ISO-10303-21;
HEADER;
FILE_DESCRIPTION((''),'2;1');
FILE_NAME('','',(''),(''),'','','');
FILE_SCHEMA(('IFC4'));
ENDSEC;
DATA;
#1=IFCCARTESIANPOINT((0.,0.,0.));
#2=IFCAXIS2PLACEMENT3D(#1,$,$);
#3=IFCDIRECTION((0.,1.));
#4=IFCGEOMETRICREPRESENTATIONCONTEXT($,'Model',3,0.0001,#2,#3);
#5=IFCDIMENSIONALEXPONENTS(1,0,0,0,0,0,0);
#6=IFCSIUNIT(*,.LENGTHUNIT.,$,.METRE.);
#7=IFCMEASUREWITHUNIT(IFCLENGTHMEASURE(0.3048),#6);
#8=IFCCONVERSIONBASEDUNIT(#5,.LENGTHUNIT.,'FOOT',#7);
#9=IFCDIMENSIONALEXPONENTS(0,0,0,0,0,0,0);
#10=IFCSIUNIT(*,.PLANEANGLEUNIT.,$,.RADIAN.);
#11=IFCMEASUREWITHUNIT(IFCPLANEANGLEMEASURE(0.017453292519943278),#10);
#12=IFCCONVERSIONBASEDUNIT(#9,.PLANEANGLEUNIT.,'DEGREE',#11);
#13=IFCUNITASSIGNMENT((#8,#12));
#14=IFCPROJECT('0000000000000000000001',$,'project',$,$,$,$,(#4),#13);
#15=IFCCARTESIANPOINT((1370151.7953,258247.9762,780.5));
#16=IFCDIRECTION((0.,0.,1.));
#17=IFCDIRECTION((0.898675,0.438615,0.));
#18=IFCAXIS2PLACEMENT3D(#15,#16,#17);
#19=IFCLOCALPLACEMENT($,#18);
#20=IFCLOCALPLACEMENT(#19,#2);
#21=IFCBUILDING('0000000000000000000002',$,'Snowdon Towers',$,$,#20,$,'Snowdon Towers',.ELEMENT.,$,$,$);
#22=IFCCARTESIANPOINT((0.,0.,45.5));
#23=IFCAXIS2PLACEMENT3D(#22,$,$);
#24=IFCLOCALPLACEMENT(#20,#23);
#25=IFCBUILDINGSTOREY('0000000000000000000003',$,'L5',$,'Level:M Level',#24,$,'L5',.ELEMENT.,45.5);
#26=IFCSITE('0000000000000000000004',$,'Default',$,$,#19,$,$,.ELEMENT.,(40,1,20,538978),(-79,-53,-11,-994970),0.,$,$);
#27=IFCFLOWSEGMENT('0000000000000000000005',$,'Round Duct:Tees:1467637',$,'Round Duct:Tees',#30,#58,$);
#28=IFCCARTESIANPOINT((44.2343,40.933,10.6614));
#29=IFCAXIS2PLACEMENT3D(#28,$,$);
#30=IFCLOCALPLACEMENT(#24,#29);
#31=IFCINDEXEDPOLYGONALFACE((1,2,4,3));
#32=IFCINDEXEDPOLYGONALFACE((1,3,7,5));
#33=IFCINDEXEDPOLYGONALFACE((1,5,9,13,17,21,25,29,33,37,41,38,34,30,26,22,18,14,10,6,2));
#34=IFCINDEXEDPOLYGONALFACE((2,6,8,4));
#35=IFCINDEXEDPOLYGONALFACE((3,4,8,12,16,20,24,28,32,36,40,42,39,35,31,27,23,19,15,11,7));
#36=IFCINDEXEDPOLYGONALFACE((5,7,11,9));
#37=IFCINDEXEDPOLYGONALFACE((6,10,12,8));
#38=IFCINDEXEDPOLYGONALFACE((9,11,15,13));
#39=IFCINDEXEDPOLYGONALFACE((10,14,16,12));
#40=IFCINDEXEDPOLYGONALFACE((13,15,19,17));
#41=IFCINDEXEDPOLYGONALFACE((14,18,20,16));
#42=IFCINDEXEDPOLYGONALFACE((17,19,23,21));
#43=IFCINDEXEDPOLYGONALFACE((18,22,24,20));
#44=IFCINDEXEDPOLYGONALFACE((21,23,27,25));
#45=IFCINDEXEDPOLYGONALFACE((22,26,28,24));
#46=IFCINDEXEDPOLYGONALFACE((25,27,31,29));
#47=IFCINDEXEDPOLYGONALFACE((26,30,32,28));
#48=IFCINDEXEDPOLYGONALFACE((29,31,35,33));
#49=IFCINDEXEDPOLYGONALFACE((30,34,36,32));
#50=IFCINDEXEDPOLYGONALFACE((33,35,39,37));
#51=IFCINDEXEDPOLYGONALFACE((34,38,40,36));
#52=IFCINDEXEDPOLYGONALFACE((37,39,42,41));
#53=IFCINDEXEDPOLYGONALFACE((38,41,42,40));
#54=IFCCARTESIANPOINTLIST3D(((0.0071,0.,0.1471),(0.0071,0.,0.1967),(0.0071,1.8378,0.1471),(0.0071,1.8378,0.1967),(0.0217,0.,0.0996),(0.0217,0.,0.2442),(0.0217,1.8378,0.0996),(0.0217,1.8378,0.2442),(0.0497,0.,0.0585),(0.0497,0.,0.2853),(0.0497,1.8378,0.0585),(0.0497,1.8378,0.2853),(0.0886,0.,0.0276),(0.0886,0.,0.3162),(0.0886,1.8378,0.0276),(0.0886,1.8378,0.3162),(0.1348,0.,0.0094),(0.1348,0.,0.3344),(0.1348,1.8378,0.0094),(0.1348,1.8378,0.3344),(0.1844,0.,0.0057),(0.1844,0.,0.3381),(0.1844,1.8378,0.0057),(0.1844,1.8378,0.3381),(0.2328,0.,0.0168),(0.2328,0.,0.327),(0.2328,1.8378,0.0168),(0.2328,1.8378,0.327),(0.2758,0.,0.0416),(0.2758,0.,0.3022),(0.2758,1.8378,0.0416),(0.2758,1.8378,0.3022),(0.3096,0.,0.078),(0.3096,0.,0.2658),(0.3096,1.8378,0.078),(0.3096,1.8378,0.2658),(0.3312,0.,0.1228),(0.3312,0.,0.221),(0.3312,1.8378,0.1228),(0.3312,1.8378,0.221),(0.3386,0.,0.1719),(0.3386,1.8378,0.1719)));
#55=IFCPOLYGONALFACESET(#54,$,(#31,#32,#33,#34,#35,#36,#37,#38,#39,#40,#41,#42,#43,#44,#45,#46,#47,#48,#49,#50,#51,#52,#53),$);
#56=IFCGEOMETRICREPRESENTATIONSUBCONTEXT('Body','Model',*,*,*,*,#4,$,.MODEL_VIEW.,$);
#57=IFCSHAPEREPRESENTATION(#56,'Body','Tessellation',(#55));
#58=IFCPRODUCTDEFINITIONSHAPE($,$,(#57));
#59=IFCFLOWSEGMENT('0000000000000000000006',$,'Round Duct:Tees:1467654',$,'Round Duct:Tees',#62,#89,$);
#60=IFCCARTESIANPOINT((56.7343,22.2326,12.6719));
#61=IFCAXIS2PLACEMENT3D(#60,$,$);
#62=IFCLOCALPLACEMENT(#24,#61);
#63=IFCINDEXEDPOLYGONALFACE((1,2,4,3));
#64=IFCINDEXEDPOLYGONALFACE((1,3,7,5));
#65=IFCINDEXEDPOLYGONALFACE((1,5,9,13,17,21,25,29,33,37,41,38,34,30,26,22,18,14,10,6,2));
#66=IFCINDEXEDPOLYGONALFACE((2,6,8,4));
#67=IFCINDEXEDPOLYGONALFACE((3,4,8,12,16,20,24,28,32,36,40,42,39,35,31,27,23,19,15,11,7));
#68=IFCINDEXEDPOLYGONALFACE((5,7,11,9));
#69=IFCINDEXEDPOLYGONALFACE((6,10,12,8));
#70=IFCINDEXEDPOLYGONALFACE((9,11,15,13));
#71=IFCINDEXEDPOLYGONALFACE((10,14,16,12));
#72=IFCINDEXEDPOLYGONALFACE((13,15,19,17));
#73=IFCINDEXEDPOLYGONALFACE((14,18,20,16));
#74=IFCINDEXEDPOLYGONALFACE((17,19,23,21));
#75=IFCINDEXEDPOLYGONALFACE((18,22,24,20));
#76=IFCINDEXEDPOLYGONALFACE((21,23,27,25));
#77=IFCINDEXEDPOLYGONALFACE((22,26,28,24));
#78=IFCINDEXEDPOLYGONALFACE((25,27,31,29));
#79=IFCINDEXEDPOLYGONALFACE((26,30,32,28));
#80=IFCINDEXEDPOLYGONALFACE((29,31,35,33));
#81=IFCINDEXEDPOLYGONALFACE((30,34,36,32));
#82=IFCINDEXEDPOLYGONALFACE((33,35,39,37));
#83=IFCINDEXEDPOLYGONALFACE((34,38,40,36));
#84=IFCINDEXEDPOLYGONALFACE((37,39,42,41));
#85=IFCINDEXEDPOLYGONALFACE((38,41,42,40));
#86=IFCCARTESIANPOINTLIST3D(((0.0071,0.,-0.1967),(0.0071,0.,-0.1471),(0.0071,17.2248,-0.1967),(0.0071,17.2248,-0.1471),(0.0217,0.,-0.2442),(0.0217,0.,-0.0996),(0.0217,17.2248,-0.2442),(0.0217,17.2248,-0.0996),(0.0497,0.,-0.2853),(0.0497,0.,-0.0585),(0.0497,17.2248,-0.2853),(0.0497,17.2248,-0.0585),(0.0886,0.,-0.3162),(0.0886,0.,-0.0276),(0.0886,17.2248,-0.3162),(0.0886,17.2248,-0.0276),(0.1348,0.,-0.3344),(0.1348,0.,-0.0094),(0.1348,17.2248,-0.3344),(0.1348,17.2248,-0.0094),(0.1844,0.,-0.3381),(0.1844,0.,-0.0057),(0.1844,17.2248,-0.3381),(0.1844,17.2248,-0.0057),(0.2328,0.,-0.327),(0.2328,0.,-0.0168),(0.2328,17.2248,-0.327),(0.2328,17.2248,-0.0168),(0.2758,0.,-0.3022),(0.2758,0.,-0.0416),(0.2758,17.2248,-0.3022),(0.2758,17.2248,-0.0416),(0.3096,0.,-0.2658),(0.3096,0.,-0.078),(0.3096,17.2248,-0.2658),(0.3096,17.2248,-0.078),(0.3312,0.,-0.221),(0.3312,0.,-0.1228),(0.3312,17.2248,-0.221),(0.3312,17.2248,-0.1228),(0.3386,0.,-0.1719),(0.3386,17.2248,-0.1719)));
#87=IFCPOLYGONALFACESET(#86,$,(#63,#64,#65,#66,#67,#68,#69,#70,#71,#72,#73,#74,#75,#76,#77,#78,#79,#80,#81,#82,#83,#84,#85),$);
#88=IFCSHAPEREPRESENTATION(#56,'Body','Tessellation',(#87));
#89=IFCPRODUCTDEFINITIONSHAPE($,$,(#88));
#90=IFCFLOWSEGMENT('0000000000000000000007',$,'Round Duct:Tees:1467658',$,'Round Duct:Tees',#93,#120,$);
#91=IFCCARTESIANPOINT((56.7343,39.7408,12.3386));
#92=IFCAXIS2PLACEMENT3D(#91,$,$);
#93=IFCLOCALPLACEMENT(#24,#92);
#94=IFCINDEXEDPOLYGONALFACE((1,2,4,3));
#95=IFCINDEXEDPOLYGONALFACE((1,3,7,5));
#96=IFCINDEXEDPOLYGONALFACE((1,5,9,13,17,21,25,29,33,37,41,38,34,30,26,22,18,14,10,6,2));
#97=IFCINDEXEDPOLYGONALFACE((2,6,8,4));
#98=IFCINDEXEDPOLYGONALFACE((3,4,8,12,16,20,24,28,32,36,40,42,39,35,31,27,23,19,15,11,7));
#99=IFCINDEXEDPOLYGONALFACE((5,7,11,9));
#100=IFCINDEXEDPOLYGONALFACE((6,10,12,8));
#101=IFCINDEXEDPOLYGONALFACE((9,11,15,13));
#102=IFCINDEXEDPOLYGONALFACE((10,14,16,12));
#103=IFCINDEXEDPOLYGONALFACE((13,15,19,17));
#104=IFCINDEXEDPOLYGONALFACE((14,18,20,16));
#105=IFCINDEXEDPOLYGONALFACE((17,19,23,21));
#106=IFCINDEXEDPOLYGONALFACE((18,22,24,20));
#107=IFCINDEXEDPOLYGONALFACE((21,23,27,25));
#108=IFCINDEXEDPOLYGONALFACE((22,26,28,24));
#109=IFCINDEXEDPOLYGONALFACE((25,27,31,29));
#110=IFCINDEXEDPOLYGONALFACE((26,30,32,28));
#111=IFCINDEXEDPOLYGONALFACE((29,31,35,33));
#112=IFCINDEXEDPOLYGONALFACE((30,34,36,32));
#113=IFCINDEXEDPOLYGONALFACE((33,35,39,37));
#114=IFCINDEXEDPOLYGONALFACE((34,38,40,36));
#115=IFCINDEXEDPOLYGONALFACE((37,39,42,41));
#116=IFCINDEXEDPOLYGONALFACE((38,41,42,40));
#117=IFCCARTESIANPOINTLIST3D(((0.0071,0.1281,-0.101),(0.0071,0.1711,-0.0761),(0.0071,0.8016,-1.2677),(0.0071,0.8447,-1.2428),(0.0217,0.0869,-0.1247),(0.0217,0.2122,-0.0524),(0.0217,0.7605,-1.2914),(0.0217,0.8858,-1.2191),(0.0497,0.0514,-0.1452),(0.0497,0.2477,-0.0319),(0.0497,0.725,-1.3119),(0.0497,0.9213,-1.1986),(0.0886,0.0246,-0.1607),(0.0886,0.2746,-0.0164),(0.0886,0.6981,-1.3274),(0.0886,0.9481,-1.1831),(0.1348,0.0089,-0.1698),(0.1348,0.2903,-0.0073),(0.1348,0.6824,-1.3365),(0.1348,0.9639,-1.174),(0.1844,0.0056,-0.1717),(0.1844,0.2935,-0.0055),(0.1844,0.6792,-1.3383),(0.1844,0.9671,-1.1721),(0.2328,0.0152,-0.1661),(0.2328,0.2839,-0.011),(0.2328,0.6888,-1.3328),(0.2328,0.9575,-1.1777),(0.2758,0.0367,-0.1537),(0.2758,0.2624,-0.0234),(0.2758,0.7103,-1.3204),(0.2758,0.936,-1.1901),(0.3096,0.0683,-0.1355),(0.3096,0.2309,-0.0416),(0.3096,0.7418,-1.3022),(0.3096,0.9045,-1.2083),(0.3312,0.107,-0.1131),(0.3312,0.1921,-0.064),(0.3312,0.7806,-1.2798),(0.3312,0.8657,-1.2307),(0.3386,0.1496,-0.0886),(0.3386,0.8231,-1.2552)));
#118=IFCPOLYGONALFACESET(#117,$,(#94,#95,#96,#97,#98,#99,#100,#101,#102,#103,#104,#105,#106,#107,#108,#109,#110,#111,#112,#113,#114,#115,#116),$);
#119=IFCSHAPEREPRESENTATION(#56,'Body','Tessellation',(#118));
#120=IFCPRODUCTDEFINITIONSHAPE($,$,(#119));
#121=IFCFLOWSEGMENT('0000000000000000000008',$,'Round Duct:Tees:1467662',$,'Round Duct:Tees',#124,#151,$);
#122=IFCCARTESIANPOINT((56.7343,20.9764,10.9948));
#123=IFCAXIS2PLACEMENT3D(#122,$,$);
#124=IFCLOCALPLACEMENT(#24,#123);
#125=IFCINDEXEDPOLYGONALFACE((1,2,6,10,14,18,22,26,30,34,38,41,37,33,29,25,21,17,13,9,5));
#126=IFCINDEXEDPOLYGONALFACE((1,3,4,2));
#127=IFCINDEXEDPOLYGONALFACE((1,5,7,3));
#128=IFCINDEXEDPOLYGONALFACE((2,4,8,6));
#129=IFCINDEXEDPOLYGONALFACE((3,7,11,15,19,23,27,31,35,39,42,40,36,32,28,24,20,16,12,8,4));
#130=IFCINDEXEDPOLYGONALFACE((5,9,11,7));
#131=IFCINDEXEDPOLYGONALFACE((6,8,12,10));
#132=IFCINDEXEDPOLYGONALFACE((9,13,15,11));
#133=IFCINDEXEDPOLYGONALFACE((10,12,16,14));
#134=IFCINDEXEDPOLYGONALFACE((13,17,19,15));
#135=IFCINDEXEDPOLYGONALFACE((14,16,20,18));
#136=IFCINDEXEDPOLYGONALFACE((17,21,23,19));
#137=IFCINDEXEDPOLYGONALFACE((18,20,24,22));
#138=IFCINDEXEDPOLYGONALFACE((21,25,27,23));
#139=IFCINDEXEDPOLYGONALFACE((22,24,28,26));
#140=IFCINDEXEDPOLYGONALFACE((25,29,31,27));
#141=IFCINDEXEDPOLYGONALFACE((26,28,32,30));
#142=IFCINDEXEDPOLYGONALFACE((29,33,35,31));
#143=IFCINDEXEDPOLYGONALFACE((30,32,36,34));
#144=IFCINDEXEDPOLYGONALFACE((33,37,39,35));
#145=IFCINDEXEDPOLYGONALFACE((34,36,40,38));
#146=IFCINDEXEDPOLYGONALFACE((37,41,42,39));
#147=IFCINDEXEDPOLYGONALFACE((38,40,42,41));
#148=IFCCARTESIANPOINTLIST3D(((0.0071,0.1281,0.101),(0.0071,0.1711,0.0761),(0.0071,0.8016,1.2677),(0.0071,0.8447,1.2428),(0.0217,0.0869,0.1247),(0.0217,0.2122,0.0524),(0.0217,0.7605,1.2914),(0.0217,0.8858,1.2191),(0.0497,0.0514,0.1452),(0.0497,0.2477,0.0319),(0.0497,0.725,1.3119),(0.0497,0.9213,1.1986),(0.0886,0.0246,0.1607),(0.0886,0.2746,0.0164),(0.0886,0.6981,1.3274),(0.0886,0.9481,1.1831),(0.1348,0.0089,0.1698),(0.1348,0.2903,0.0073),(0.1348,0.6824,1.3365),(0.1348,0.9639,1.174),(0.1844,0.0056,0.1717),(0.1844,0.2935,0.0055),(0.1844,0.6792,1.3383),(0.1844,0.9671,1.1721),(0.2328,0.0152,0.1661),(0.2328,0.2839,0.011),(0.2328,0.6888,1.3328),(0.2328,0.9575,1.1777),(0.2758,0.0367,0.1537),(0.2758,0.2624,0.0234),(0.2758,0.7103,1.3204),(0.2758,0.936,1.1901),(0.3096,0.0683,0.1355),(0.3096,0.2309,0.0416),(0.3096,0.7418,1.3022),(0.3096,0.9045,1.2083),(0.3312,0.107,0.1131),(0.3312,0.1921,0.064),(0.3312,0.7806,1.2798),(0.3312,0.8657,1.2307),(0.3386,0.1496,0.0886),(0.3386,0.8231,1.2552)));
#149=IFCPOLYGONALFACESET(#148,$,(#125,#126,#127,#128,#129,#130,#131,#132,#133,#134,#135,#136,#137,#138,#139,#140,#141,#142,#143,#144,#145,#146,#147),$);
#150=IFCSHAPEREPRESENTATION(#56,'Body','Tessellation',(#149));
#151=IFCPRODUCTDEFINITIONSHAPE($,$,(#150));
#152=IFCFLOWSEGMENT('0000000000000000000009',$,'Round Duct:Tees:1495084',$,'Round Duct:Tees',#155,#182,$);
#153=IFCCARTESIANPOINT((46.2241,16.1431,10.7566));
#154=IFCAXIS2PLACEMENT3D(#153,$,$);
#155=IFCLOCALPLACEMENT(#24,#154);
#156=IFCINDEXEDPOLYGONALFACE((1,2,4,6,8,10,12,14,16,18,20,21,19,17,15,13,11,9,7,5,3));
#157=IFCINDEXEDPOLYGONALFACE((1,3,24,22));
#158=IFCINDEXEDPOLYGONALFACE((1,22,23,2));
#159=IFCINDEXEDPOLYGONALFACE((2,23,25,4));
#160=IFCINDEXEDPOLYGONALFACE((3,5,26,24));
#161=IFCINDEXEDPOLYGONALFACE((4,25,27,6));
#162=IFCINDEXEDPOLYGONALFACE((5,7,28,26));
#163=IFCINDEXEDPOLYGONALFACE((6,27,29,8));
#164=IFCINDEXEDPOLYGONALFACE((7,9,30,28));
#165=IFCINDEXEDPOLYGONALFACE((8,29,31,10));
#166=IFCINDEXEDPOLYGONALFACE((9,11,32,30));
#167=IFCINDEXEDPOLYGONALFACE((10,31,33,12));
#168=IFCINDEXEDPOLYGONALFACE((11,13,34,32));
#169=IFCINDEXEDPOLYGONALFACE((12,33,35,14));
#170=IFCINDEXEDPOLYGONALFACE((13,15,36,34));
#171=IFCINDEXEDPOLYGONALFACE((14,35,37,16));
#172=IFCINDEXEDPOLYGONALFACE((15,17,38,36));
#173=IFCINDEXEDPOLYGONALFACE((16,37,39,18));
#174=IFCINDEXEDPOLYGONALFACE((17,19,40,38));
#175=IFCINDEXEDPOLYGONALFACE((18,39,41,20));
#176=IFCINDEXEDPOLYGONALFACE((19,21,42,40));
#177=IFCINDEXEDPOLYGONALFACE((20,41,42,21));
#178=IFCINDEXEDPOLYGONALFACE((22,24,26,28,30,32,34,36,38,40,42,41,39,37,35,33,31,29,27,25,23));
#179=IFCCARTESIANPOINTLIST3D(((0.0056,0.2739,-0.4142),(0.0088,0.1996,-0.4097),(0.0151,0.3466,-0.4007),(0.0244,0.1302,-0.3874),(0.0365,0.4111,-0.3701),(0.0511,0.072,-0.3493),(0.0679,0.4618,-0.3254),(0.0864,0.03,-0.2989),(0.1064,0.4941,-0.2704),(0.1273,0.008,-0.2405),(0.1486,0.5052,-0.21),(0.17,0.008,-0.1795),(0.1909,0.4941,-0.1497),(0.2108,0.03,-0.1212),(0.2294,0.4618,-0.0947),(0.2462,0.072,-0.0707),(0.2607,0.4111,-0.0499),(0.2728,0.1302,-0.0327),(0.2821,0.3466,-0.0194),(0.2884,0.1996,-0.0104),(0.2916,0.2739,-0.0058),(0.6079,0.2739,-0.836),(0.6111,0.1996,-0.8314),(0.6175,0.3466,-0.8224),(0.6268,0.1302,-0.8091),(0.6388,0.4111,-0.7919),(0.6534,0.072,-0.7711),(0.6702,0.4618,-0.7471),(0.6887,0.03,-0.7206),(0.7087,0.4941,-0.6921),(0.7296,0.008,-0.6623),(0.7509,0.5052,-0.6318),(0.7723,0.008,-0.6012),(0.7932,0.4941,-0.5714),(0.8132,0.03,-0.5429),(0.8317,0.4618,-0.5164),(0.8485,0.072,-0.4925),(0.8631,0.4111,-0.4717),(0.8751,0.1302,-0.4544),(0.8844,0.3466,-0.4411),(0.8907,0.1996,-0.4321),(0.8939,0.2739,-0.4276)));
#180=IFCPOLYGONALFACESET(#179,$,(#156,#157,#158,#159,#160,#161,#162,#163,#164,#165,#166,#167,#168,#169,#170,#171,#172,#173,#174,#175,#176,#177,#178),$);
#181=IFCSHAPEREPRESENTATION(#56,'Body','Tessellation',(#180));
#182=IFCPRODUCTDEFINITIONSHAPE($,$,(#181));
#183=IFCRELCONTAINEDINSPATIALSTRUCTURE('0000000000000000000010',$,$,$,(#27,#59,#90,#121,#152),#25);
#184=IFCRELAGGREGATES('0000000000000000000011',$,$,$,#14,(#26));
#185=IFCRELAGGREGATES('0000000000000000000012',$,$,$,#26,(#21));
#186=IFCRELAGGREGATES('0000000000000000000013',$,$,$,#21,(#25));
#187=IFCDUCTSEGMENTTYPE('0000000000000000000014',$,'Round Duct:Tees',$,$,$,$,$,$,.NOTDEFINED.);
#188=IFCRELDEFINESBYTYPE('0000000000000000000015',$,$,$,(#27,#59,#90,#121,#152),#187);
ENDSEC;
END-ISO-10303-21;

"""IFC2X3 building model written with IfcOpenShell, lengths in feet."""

from ifc_helpers import new_model, entity, si_unit, converted_unit, direction, frame, frame_2d, origin, place, context, subcontext, project, spatial, circle, extrude, type_object, element, save


model = new_model("IFC2X3")

# Units and contexts
model_context = context("Model", 3, precision=0.0001, world=origin(), true_north=direction((0.0, 1.0)))
body_context = subcontext(model_context, "Body", "Model", "MODEL_VIEW")
ifc_project = project(units=[converted_unit("LENGTHUNIT", "FOOT", entity("IfcLengthMeasure", 0.3048), si_unit("LENGTHUNIT", "METRE"), dimensions=[1, 0, 0, 0, 0, 0, 0]), converted_unit("PLANEANGLEUNIT", "DEGREE", entity("IfcPlaneAngleMeasure", 0.017453292519943278), si_unit("PLANEANGLEUNIT", "RADIAN"), dimensions=[0, 0, 0, 0, 0, 0, 0])], contexts=[model_context])

# Site, building, storey
site_placement = place(None, frame((1370151.7953, 258247.9762, 780.5), z_axis=(0.0, 0.0, 1.0), x_axis=(0.898675, 0.438615, 0.0)))
site = spatial("IfcSite", under=ifc_project, at=site_placement, Name="Default", CompositionType="ELEMENT", RefLatitude=(40, 1, 20, 538978), RefLongitude=(-79, -53, -11, -994970), RefElevation=0.0)
building_placement = place(site_placement, origin())
building = spatial("IfcBuilding", under=site, at=building_placement, Name="Snowdon Towers", LongName="Snowdon Towers", CompositionType="ELEMENT")
storey_placement = place(building_placement, frame((0.0, 0.0, 45.5)))
storey = spatial("IfcBuildingStorey", under=building, at=storey_placement, Name="L5", ObjectType="Level:M Level", LongName="L5", CompositionType="ELEMENT", Elevation=45.5)

# Flow segments
duct_segment_type = type_object("IfcDuctSegmentType", Name="Round Duct:Tees", PredefinedType="NOTDEFINED")
flow_segment_1_placement = place(storey_placement, frame((44.2343, 40.933, 10.6614)))
element("IfcFlowSegment", 1, at=flow_segment_1_placement, inside=storey, type_object=duct_segment_type, Name="Round Duct:Tees:1467637", ObjectType="Round Duct:Tees", context=body_context, shape_type="SweptSolid", body=[
    extrude(circle(Radius=0.1667, at=frame_2d((0.0, 0.0), x_axis=(1.0, 0.0))), frame((0.1719, 0.0, 0.1719), z_axis=(0.0, 1.0, 0.0), x_axis=(1.0, 0.0, 0.0)), (0.0, 0.0, 1.0), 1.8378),
])
flow_segment_2_placement = place(storey_placement, frame((56.7343, 22.2326, 12.6719)))
element("IfcFlowSegment", 2, at=flow_segment_2_placement, inside=storey, type_object=duct_segment_type, Name="Round Duct:Tees:1467654", ObjectType="Round Duct:Tees", context=body_context, shape_type="SweptSolid", body=[
    extrude(circle(Radius=0.1667, at=frame_2d((0.0, 0.0), x_axis=(1.0, 0.0))), frame((0.1719, 0.0, -0.1719), z_axis=(0.0, 1.0, 0.0), x_axis=(1.0, 0.0, 0.0)), (0.0, 0.0, 1.0), 17.2248),
])
flow_segment_3_placement = place(storey_placement, frame((56.7343, 39.7408, 12.3386)))
element("IfcFlowSegment", 3, at=flow_segment_3_placement, inside=storey, type_object=duct_segment_type, Name="Round Duct:Tees:1467658", ObjectType="Round Duct:Tees", context=body_context, shape_type="SweptSolid", body=[
    extrude(circle(Radius=0.1667, at=frame_2d((0.0, 0.0), x_axis=(1.0, 0.0))), frame((0.1719, 0.8231, -1.2552), z_axis=(0.0, -0.5, 0.866025), x_axis=(1.0, 0.0, 0.0)), (0.0, 0.0, 1.0), 1.3472),
])
flow_segment_4_placement = place(storey_placement, frame((56.7343, 20.9764, 10.9948)))
element("IfcFlowSegment", 4, at=flow_segment_4_placement, inside=storey, type_object=duct_segment_type, Name="Round Duct:Tees:1467662", ObjectType="Round Duct:Tees", context=body_context, shape_type="SweptSolid", body=[
    extrude(circle(Radius=0.1667, at=frame_2d((0.0, 0.0), x_axis=(1.0, 0.0))), frame((0.1719, 0.1496, 0.0886), z_axis=(0.0, 0.5, 0.866025), x_axis=(1.0, 0.0, 0.0)), (0.0, 0.0, 1.0), 1.3472),
])
flow_segment_5_placement = place(storey_placement, frame((46.2241, 16.1431, 10.7566)))
element("IfcFlowSegment", 5, at=flow_segment_5_placement, inside=storey, type_object=duct_segment_type, Name="Round Duct:Tees:1495084", ObjectType="Round Duct:Tees", context=body_context, shape_type="SweptSolid", body=[
    extrude(circle(Radius=0.25, at=frame_2d((0.0, 0.0), x_axis=(1.0, 0.0))), frame((0.1486, 0.2552, -0.21), z_axis=(0.819152, 0.0, -0.573576), x_axis=(0.0, 1.0, 0.0)), (0.0, 0.0, 1.0), 0.7353),
])

save(model, "model.ifc")
